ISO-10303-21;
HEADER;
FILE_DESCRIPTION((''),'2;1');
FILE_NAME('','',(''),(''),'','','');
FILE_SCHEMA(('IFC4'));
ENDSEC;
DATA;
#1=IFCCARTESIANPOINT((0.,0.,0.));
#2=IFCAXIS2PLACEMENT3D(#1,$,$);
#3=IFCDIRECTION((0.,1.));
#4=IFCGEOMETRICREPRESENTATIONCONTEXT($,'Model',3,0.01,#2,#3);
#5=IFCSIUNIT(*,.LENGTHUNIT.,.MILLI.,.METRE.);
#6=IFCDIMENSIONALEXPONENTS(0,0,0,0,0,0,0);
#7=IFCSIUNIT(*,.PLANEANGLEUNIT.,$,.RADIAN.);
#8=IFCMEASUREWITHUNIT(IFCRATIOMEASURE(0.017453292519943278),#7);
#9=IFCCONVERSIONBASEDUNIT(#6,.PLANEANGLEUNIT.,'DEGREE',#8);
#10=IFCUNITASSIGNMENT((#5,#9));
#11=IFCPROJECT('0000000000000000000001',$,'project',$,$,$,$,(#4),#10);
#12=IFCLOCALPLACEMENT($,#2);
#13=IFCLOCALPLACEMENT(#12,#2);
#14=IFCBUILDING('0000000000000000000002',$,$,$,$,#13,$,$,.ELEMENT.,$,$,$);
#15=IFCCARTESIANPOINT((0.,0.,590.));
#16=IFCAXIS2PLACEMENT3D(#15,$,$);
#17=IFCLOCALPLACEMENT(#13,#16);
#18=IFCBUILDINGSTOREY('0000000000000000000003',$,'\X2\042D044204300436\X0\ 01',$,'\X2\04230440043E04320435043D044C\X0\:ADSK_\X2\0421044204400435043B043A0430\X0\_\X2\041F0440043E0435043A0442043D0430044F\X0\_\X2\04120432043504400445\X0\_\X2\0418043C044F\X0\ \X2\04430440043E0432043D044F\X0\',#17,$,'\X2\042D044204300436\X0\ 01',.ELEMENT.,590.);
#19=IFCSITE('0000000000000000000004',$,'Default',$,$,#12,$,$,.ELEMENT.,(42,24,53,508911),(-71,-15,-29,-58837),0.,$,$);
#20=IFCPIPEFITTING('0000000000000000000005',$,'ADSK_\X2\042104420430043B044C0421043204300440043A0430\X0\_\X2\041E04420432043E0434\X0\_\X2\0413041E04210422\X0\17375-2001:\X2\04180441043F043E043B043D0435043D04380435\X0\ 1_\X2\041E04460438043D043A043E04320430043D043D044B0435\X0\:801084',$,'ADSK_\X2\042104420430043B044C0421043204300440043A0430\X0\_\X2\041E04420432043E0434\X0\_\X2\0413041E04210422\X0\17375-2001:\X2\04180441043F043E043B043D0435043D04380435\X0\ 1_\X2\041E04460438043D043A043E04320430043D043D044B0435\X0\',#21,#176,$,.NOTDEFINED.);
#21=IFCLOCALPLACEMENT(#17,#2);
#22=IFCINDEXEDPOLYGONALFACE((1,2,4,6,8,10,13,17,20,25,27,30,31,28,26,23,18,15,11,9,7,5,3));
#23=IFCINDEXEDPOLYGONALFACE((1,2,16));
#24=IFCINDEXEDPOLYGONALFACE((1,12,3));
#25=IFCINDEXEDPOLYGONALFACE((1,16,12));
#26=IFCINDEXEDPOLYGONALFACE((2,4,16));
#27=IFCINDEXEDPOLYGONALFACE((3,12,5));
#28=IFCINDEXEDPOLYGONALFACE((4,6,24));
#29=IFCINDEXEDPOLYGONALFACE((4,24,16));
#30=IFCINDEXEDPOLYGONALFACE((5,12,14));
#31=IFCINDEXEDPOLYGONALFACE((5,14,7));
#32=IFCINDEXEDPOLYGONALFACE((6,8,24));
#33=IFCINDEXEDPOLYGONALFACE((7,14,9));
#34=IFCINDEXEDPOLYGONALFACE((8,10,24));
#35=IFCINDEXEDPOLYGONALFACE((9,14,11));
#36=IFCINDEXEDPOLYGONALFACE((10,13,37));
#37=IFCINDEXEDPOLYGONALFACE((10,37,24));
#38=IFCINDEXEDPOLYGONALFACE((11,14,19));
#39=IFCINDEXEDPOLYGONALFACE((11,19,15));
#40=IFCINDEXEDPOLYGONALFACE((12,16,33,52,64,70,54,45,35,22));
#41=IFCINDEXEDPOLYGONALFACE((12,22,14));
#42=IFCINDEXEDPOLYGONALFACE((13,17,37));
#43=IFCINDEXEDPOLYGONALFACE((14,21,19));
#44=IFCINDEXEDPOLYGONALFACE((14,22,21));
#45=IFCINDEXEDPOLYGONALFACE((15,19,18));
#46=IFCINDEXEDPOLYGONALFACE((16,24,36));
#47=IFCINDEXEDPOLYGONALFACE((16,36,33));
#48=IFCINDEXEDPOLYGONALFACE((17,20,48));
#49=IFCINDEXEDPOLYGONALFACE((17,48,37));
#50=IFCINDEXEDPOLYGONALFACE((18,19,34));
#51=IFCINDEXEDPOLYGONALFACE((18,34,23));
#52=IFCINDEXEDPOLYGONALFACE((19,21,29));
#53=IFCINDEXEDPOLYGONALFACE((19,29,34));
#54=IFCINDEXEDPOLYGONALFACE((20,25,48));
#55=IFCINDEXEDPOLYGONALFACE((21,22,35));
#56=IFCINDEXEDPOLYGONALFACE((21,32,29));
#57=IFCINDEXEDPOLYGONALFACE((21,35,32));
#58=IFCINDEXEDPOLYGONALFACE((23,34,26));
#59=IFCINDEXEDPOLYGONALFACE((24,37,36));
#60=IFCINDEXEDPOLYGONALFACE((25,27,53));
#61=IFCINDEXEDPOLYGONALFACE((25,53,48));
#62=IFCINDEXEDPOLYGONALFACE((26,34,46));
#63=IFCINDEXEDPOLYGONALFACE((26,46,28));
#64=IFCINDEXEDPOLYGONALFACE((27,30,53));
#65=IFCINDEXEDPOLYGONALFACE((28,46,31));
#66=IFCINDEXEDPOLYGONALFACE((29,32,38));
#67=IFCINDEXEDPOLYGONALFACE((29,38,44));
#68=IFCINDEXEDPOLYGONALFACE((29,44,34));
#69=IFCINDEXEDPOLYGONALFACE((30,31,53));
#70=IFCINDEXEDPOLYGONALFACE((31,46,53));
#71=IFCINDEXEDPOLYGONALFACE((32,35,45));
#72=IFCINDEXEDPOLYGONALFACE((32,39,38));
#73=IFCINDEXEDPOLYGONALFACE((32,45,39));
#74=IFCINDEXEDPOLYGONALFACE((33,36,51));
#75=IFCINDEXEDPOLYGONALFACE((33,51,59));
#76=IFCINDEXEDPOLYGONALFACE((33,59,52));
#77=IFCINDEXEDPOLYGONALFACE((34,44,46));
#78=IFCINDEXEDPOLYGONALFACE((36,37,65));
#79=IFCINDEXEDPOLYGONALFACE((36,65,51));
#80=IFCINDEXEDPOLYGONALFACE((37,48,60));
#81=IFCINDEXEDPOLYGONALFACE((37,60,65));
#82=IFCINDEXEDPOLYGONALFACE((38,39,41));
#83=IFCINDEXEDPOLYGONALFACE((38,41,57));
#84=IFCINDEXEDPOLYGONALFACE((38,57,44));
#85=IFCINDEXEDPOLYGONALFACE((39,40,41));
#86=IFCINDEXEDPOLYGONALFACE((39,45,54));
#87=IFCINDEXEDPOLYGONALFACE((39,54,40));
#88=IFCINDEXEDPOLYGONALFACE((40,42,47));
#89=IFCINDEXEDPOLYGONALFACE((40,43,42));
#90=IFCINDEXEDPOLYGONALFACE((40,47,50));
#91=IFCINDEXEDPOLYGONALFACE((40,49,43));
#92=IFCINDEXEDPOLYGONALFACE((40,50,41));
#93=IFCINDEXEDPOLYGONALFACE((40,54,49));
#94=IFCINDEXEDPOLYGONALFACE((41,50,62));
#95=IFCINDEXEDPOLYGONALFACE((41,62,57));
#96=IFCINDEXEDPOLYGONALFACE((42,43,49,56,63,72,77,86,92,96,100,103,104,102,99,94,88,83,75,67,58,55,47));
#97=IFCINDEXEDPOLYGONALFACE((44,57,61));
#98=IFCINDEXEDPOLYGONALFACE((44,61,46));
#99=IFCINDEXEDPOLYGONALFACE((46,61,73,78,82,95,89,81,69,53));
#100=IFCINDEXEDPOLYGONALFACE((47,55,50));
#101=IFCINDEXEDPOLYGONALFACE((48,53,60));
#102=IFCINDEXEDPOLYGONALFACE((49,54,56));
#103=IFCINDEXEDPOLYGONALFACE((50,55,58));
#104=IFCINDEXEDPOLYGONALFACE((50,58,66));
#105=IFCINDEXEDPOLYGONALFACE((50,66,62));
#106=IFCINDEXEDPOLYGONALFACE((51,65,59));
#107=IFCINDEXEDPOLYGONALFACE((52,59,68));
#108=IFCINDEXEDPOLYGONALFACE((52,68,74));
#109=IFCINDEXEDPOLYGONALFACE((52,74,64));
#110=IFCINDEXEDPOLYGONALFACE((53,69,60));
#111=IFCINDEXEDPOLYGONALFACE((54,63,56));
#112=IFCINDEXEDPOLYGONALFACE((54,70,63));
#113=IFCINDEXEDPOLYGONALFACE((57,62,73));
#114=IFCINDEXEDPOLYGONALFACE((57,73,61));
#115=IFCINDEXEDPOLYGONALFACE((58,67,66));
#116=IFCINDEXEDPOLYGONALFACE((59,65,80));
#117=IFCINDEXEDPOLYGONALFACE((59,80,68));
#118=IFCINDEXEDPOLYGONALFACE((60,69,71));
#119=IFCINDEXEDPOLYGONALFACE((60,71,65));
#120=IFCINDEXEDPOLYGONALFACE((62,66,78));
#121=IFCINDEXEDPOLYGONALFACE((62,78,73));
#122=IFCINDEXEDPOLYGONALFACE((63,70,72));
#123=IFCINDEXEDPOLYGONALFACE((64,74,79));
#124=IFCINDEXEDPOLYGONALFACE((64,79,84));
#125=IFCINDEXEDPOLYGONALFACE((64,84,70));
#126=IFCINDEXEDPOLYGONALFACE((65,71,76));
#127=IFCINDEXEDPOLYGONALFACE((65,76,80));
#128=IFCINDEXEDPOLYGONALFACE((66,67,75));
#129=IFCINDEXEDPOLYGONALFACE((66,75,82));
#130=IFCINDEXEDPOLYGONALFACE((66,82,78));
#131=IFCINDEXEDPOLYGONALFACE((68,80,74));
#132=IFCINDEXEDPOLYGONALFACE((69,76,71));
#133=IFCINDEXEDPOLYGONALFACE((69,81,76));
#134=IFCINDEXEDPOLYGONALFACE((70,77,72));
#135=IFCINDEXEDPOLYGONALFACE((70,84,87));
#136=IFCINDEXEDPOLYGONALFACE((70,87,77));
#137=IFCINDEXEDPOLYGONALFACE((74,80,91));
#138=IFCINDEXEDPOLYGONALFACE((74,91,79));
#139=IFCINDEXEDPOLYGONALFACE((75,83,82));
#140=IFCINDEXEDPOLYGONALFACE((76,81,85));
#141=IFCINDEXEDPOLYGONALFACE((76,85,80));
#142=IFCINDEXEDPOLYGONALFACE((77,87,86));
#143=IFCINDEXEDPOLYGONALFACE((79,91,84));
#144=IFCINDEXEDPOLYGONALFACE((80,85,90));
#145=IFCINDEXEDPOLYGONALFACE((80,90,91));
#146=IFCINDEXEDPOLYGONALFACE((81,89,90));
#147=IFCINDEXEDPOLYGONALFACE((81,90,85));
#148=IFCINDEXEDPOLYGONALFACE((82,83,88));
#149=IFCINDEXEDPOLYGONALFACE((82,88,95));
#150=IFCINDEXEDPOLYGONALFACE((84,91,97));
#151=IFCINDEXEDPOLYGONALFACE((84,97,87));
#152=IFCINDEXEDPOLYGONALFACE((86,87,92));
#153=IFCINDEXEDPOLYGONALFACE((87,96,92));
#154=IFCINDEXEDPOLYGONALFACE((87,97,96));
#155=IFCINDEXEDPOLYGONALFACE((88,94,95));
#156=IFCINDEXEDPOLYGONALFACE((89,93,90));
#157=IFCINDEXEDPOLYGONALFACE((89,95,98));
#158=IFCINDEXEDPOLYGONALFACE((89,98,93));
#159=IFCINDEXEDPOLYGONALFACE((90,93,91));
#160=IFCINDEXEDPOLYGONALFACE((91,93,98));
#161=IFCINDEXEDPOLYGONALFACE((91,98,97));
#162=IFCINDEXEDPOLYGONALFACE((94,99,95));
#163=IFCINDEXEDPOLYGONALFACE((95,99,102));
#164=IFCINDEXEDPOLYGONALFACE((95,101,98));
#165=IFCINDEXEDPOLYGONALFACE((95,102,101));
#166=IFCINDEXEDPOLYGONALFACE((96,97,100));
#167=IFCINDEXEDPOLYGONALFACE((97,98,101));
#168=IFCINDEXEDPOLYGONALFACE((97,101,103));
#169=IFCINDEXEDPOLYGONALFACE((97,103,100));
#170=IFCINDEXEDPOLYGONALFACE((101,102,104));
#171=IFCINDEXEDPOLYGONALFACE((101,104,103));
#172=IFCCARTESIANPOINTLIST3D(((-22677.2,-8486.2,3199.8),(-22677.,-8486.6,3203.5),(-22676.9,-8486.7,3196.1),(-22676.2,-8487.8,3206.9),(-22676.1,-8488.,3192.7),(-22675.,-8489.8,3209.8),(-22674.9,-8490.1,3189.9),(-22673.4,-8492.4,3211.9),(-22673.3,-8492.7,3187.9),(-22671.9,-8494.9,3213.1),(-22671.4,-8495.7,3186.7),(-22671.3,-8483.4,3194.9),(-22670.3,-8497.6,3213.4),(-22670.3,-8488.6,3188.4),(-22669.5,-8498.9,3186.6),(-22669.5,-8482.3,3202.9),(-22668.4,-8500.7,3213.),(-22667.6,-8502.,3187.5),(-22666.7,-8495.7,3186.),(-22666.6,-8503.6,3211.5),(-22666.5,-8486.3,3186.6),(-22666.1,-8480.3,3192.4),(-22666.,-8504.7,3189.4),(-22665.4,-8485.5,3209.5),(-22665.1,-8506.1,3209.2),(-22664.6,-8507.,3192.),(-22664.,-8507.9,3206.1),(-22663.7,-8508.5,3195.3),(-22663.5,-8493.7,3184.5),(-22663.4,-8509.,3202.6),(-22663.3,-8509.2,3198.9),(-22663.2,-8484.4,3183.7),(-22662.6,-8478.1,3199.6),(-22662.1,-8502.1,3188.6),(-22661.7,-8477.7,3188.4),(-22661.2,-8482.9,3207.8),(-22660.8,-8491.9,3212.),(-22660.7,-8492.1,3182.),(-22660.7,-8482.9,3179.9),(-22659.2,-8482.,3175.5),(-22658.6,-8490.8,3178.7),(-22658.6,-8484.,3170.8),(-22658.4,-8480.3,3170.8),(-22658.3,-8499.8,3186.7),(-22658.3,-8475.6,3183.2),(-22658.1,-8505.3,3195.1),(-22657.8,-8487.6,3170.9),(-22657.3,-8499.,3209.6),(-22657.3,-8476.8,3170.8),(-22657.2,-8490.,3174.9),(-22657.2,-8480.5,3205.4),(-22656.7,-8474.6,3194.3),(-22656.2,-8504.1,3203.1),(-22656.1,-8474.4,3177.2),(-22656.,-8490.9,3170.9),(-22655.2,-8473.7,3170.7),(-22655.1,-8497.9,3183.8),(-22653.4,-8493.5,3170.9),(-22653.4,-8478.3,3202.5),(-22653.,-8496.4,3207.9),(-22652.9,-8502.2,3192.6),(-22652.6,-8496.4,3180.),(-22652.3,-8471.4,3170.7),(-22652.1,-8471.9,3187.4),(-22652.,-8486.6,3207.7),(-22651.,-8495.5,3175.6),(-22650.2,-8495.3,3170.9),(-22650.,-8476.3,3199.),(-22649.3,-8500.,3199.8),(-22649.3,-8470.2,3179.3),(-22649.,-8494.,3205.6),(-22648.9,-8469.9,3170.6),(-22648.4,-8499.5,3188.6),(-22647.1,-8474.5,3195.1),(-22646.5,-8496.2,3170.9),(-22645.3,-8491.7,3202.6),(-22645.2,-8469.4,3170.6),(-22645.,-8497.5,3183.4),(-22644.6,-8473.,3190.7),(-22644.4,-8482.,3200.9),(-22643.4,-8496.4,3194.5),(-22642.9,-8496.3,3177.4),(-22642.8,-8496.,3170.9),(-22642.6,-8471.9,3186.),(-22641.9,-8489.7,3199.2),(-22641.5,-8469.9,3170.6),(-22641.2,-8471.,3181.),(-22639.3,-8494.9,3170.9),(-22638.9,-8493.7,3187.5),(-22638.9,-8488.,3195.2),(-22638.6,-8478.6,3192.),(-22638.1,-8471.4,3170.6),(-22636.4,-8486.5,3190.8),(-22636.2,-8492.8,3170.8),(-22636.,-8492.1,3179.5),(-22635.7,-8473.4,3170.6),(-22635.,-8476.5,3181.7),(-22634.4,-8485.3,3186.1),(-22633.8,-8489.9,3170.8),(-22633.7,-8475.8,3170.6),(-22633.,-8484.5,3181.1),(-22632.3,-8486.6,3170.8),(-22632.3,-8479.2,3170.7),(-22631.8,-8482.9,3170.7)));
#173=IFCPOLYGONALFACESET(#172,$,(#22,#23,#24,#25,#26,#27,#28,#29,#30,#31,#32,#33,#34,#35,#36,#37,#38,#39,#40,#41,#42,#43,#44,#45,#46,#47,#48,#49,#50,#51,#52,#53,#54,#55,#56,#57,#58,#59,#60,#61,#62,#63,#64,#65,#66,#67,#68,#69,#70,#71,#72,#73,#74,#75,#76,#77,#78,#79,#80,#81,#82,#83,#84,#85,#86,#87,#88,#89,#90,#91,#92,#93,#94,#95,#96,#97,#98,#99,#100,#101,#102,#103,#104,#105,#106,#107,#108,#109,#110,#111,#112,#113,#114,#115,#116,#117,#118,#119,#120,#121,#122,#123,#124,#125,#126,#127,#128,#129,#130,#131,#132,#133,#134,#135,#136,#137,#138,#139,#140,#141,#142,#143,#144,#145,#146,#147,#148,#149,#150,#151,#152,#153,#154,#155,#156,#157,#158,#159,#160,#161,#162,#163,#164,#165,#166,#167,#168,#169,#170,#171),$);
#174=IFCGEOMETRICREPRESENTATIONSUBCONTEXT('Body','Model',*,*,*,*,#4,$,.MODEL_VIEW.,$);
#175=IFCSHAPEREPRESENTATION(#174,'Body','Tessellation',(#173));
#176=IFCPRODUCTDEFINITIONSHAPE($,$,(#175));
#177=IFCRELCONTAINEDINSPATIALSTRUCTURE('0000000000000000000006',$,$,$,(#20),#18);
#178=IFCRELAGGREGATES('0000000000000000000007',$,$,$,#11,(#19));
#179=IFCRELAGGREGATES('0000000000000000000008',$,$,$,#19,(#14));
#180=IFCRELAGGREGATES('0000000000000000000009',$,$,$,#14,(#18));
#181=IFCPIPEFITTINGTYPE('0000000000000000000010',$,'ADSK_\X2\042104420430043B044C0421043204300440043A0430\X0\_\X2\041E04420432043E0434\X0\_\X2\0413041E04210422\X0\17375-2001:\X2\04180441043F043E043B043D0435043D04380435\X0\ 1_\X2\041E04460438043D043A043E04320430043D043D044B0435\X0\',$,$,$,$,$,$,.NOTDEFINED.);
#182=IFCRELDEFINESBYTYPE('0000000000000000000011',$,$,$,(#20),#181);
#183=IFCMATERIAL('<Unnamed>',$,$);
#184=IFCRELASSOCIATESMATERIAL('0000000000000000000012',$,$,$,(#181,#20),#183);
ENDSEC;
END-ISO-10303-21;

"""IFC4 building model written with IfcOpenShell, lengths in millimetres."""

from ifc_helpers import new_model, entity, si_unit, converted_unit, direction, frame, origin, place, context, subcontext, project, spatial, source, transform, mapped, material, type_object, type_shapes, element, save


model = new_model("IFC4")

# Units and contexts
model_context = context("Model", 3, precision=0.01, world=origin(), true_north=direction((0.0, 1.0)))
body_context = subcontext(model_context, "Body", "Model", "MODEL_VIEW")
ifc_project = project(units=[si_unit("LENGTHUNIT", "METRE", prefix="MILLI"), converted_unit("PLANEANGLEUNIT", "DEGREE", entity("IfcRatioMeasure", 0.017453292519943278), si_unit("PLANEANGLEUNIT", "RADIAN"), dimensions=[0, 0, 0, 0, 0, 0, 0])], contexts=[model_context])

# Site, building, storey
site_placement = place(None, origin())
site = spatial("IfcSite", under=ifc_project, at=site_placement, Name="Default", CompositionType="ELEMENT", RefLatitude=(42, 24, 53, 508911), RefLongitude=(-71, -15, -29, -58837), RefElevation=0.0)
building_placement = place(site_placement, origin())
building = spatial("IfcBuilding", under=site, at=building_placement, CompositionType="ELEMENT")
storey_placement = place(building_placement, frame((0.0, 0.0, 590.0)))
storey = spatial("IfcBuildingStorey", under=building, at=storey_placement, Name="Этаж 01", ObjectType="Уровень:ADSK_Стрелка_Проектная_Вверх_Имя уровня", LongName="Этаж 01", CompositionType="ELEMENT", Elevation=590.0)

# Shared definitions
ifc_material_1 = material(Name="<Unnamed>")

# Pipe fitting
pipe_fitting_type_1 = type_object("IfcPipeFittingType", Name="ADSK_СтальСварка_Отвод_ГОСТ17375-2001:Исполнение 1_Оцинкованные", PredefinedType="NOTDEFINED", material=ifc_material_1)
ifc_direction_1 = entity("IfcDirection", [0.0, 0.0, 1.0])
trimmed_curve_1 = entity("IfcTrimmedCurve", entity("IfcCircle", entity("IfcAxis2Placement2D", entity("IfcCartesianPoint", [-29.1, 0.0]), entity("IfcDirection", [0.0, 1.0])), 29.1), [entity("IfcParameterValue", 270.0)], [entity("IfcParameterValue", 0.260764)], True, "PARAMETER")
shared_shape_1 = source(origin(), body_context, "Body", "AdvancedSweptSolid", [
    entity("IfcSurfaceCurveSweptAreaSolid", entity("IfcCircleProfileDef", "AREA", None, entity("IfcAxis2Placement2D", entity("IfcCartesianPoint", [0.0, 0.0]), entity("IfcDirection", [1.0, 0.0])), 13.5), entity("IfcAxis2Placement3D", entity("IfcCartesianPoint", [-29.2, 0.0, 0.0]), ifc_direction_1, entity("IfcDirection", [0.0, -1.0, 0.0])), trimmed_curve_1, 0.0, 90.3, entity("IfcSurfaceOfLinearExtrusion", entity("IfcArbitraryOpenProfileDef", "CURVE", None, trimmed_curve_1), entity("IfcAxis2Placement3D", entity("IfcCartesianPoint", [0.0, 0.0, -304.8])), ifc_direction_1, 1.0)),
])
type_shapes(pipe_fitting_type_1, [shared_shape_1])
pipe_fitting_1_placement = place(storey_placement, frame((-22645.2, -8482.5, 3200.0), z_axis=(-0.518173, 0.855243, -0.007512), x_axis=(0.855267, 0.518188, 0.0)))
element("IfcPipeFitting", 1, at=pipe_fitting_1_placement, inside=storey, type_object=pipe_fitting_type_1, material=ifc_material_1, Name="ADSK_СтальСварка_Отвод_ГОСТ17375-2001:Исполнение 1_Оцинкованные:801084", ObjectType="ADSK_СтальСварка_Отвод_ГОСТ17375-2001:Исполнение 1_Оцинкованные", PredefinedType="NOTDEFINED", context=body_context, shape_type="MappedRepresentation", body=[
    mapped(shared_shape_1, transform((0.0, 0.0, 0.0), scale=1.0)),
])

save(model, "model.ifc")
